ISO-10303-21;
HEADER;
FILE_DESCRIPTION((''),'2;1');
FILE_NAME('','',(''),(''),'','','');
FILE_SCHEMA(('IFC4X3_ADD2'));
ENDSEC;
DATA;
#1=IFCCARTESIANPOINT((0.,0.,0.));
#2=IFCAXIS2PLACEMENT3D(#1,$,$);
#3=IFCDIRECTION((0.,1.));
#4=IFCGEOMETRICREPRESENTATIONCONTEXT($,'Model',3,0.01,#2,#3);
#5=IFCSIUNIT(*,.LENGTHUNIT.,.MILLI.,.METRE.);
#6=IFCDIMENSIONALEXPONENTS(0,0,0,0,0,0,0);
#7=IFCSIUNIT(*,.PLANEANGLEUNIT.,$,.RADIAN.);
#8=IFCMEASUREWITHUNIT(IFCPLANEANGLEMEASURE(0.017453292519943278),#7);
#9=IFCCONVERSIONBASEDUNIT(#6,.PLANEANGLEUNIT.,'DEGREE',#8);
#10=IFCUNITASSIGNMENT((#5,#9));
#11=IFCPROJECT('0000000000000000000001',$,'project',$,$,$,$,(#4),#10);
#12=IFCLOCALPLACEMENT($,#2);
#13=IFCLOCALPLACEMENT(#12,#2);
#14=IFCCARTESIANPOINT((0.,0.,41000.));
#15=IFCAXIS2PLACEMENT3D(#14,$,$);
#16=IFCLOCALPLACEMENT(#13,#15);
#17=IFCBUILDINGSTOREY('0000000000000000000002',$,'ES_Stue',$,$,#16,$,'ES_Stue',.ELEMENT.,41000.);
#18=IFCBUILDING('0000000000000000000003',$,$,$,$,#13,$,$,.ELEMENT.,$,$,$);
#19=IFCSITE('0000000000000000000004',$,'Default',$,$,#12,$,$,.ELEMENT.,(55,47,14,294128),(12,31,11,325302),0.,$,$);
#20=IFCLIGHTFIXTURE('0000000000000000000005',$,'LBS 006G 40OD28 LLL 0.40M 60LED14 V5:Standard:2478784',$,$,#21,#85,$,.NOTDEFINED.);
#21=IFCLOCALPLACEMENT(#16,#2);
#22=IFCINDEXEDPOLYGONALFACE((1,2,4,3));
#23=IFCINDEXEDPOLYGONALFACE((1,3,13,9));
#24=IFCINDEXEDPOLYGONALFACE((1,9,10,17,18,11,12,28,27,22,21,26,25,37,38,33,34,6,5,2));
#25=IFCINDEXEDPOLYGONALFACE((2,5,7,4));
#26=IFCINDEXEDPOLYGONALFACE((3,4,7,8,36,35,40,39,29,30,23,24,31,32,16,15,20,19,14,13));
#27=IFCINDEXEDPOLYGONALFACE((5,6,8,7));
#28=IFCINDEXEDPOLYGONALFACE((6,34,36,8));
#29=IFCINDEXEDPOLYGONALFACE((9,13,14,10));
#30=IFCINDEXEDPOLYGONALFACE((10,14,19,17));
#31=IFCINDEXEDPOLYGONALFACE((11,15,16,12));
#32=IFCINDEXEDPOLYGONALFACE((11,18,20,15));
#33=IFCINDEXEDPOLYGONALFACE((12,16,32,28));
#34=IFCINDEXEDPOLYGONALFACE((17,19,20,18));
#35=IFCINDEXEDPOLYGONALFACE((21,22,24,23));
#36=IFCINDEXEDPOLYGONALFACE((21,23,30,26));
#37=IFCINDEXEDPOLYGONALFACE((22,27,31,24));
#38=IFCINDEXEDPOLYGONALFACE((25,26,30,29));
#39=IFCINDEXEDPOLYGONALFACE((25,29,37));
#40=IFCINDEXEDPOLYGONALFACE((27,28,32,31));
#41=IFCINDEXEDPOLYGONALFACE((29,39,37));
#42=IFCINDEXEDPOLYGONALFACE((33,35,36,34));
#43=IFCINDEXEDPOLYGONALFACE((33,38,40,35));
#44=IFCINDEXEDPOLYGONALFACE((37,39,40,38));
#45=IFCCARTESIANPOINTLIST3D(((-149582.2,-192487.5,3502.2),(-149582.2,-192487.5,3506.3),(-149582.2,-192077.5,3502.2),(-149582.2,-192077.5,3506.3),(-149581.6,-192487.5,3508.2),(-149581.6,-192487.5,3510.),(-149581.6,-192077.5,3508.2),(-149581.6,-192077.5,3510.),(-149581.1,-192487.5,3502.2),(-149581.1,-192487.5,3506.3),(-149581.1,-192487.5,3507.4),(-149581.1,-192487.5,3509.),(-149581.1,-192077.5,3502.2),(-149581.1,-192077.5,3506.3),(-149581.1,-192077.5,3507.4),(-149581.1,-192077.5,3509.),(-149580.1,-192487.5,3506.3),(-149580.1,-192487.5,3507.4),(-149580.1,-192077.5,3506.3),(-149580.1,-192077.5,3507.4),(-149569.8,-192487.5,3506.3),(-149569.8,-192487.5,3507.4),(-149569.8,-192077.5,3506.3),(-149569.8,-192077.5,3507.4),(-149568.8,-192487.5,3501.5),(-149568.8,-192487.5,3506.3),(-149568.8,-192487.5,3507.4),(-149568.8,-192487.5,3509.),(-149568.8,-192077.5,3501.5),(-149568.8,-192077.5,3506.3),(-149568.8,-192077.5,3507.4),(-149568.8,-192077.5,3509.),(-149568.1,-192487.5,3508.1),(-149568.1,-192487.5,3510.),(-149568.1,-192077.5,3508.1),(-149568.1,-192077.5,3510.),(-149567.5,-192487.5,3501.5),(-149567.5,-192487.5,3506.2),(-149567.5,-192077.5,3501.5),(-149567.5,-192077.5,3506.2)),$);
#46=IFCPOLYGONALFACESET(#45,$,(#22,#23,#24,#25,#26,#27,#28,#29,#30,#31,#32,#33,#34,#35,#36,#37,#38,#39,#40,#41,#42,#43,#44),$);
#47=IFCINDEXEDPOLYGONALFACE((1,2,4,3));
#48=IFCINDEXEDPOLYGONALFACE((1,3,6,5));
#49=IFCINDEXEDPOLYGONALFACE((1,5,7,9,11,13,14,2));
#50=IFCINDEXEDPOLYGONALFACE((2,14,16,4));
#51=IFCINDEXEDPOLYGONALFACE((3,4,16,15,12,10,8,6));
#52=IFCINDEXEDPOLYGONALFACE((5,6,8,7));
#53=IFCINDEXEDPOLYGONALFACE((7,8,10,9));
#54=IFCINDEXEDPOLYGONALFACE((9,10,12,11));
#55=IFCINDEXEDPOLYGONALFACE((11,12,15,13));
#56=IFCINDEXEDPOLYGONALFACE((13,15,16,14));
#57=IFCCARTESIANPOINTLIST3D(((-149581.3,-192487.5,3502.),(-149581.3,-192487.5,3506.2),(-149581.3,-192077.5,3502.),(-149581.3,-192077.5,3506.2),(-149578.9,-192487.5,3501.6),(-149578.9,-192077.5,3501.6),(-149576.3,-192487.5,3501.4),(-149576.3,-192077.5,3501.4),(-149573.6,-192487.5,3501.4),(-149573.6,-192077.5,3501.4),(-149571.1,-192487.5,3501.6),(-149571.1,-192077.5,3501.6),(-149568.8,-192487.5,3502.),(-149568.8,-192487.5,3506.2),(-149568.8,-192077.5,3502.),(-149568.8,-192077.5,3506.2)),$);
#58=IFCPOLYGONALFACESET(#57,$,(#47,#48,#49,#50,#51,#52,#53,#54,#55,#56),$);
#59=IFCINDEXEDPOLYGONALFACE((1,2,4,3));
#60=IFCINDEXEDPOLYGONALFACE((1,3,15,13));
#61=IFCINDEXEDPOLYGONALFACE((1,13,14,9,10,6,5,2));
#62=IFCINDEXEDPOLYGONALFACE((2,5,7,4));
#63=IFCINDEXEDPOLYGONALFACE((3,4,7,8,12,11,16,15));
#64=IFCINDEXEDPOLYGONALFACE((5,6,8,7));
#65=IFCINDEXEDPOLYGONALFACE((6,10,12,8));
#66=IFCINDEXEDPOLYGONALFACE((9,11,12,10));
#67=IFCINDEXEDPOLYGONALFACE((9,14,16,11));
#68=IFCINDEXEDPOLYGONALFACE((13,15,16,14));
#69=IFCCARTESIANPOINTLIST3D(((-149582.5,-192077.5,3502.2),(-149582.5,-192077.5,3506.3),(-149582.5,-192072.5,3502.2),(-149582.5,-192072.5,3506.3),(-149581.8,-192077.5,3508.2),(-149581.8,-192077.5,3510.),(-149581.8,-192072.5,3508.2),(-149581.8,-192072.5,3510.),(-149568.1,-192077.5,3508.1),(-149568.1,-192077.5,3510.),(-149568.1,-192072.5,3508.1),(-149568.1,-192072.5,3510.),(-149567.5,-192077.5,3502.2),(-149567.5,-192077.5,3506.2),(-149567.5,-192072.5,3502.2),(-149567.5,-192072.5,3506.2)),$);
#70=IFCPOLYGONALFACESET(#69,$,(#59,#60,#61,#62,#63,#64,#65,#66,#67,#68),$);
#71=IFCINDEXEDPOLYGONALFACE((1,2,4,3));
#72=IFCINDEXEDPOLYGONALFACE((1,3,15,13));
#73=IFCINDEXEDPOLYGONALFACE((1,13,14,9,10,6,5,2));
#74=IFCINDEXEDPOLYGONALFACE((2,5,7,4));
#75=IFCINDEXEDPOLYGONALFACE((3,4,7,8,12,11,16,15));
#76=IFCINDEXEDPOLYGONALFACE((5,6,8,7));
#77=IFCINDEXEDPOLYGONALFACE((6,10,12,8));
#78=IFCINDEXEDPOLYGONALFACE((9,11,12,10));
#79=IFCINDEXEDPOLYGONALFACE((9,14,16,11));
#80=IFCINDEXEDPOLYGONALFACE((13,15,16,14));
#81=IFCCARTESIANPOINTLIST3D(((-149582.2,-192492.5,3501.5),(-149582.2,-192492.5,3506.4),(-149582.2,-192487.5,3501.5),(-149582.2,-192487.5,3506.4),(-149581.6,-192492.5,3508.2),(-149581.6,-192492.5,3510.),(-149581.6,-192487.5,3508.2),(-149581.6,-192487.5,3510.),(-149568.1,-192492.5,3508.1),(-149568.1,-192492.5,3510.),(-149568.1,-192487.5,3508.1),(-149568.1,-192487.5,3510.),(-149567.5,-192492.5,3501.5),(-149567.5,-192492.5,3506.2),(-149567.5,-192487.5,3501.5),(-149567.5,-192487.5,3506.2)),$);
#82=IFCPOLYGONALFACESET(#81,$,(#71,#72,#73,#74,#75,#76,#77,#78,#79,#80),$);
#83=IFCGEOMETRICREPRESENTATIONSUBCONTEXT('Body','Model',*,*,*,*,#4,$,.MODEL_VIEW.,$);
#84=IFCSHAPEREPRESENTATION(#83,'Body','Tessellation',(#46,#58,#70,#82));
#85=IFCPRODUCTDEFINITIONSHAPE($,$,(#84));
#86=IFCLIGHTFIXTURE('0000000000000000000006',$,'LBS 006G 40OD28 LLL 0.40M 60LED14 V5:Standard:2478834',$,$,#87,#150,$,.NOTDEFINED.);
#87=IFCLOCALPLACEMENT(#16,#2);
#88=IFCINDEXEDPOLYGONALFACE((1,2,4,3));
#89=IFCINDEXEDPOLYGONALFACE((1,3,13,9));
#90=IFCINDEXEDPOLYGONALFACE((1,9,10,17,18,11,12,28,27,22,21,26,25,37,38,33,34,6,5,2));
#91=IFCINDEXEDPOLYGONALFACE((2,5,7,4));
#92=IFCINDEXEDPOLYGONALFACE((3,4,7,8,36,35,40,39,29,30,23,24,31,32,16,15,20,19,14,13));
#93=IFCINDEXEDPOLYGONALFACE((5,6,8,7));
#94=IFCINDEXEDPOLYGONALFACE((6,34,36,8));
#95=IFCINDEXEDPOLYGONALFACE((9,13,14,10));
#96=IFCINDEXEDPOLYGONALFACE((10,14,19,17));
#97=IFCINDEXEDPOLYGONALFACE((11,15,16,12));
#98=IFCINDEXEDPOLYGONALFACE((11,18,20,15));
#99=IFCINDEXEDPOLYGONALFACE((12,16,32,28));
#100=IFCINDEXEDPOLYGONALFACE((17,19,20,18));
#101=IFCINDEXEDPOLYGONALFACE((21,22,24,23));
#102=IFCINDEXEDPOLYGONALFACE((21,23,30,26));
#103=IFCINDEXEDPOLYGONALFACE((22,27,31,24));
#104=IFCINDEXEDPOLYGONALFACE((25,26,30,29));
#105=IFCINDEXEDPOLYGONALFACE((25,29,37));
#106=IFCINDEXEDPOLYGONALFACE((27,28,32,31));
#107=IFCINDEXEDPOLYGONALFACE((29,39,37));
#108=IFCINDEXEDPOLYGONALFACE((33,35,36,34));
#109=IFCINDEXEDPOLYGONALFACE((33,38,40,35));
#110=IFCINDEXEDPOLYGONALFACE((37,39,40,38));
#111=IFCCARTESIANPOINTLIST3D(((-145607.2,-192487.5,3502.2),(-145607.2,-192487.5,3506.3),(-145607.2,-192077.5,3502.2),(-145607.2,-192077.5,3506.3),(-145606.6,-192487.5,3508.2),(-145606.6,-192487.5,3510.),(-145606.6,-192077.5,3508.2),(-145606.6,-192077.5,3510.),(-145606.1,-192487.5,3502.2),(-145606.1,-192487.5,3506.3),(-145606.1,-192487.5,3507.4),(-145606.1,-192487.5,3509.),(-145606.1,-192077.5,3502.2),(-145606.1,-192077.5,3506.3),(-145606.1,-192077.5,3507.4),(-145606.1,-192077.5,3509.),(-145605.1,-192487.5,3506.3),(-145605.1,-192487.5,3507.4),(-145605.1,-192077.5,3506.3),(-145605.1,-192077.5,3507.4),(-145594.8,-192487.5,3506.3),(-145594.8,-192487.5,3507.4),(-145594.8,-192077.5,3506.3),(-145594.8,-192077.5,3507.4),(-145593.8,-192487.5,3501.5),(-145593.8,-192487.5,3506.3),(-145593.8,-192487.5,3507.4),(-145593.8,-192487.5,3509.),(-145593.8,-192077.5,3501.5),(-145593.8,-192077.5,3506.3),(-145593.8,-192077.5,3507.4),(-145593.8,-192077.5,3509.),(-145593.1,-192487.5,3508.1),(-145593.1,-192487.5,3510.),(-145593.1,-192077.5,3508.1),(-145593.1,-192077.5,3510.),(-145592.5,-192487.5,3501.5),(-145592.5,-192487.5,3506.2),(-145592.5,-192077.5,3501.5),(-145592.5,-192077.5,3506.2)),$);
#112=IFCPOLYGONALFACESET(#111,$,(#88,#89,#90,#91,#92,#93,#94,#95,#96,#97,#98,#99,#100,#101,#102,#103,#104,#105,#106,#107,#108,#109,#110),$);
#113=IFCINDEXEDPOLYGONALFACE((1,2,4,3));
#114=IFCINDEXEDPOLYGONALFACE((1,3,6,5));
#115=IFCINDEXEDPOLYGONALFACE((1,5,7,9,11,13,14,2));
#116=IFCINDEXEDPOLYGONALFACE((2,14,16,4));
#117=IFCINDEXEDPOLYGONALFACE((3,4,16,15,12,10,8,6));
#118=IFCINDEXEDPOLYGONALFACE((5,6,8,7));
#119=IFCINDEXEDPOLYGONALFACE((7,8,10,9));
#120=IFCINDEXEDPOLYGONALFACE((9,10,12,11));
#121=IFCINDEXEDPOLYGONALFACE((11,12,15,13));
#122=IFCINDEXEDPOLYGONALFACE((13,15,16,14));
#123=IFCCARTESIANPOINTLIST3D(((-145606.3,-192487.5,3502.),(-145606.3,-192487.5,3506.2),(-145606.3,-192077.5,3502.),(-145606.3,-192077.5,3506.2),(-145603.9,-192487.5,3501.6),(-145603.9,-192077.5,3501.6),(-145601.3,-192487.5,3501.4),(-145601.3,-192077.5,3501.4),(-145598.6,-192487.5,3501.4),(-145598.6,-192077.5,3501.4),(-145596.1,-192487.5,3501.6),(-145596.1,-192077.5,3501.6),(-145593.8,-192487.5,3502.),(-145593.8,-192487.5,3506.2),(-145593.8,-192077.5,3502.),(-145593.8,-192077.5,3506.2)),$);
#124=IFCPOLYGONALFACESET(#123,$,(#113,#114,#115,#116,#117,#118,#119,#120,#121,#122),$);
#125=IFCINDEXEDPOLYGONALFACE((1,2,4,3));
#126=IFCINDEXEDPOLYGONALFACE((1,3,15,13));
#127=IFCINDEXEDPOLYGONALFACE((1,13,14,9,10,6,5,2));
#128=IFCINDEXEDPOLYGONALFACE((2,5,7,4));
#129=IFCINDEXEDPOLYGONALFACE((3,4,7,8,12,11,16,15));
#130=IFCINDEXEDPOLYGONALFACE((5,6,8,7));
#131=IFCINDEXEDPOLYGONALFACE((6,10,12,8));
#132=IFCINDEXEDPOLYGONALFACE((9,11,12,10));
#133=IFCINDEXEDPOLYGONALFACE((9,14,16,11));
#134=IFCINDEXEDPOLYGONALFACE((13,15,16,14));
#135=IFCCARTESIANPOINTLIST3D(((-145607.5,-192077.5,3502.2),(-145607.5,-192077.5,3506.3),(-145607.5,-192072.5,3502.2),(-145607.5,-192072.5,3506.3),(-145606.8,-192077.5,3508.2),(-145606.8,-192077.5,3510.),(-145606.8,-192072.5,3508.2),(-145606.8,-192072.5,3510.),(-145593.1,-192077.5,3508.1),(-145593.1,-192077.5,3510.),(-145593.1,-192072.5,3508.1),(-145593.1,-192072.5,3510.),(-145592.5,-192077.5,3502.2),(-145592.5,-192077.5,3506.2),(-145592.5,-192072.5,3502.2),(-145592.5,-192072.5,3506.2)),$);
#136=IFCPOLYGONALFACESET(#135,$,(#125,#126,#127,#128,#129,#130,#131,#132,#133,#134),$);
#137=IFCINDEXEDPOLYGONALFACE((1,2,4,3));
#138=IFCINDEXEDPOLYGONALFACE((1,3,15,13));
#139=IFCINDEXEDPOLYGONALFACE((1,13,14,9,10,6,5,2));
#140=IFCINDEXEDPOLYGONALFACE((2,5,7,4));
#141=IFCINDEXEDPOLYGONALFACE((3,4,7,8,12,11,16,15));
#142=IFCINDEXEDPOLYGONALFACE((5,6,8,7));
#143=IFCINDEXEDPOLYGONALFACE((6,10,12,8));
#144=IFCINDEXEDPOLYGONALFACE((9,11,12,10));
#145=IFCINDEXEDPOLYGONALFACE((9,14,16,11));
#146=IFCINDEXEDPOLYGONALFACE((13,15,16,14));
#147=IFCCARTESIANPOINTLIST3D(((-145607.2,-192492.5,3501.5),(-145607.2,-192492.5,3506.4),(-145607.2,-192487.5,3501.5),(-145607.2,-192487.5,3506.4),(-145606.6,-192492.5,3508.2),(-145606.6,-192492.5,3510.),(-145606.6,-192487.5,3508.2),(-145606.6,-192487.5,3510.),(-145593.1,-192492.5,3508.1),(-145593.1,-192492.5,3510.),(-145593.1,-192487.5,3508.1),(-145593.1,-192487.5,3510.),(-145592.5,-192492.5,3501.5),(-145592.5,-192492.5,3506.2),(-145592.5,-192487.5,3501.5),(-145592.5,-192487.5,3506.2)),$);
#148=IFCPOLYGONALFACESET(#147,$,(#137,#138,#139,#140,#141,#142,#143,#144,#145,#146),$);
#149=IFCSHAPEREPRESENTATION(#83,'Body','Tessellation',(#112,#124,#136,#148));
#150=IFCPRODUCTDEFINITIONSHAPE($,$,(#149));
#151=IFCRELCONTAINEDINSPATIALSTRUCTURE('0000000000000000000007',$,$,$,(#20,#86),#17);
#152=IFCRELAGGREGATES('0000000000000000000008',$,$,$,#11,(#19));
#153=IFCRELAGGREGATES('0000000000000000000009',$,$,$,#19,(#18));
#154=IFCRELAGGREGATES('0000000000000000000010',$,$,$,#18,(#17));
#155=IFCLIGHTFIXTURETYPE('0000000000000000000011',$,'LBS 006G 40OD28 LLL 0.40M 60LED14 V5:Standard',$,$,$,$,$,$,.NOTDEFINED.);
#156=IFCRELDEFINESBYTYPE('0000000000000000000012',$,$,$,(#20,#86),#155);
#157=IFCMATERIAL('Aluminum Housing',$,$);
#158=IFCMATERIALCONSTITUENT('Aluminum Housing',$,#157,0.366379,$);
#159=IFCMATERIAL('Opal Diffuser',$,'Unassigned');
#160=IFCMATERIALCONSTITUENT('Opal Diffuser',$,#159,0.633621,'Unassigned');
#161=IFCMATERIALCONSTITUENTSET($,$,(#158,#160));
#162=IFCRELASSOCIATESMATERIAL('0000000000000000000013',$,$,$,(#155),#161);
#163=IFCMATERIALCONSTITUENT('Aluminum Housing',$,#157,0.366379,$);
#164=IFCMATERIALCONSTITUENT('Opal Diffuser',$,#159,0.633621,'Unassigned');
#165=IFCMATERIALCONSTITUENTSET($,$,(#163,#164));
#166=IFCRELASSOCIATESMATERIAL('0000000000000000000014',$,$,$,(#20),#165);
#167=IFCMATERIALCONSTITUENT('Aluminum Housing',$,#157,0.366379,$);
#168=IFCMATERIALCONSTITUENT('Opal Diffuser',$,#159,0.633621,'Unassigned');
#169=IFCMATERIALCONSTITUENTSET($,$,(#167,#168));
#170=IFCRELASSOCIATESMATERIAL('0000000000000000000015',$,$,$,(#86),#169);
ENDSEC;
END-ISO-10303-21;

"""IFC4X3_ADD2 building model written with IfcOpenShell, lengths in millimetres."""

from ifc_helpers import new_model, entity, si_unit, converted_unit, direction, frame, origin, place, context, subcontext, project, spatial, polyline, outline, extrude, source, transform, mapped, material, constituent, constituent_set, type_object, type_shapes, element, save


model = new_model("IFC4X3_ADD2")

# Units and contexts
model_context = context("Model", 3, precision=0.01, world=origin(), true_north=direction((0.0, 1.0)))
body_context = subcontext(model_context, "Body", "Model", "MODEL_VIEW")
ifc_project = project(units=[si_unit("LENGTHUNIT", "METRE", prefix="MILLI"), converted_unit("PLANEANGLEUNIT", "DEGREE", entity("IfcPlaneAngleMeasure", 0.017453292519943278), si_unit("PLANEANGLEUNIT", "RADIAN"), dimensions=[0, 0, 0, 0, 0, 0, 0])], contexts=[model_context])

# Site, building, storey
site_placement = place(None, origin())
site = spatial("IfcSite", under=ifc_project, at=site_placement, Name="Default", CompositionType="ELEMENT", RefLatitude=(55, 47, 14, 294128), RefLongitude=(12, 31, 11, 325302), RefElevation=0.0)
building_placement = place(site_placement, origin())
building = spatial("IfcBuilding", under=site, at=building_placement, CompositionType="ELEMENT")
storey_placement = place(building_placement, frame((0.0, 0.0, 41000.0)))
storey = spatial("IfcBuildingStorey", under=building, at=storey_placement, Name="ES_Stue", LongName="ES_Stue", CompositionType="ELEMENT", Elevation=41000.0)

# Light fixtures
ifc_material_1 = material(Name="Aluminum Housing")
ifc_constituent_1 = constituent(ifc_material_1, Name="Aluminum Housing", fraction=0.366379)
ifc_material_2 = material(Name="Opal Diffuser", Category="Unassigned")
ifc_constituent_2 = constituent(ifc_material_2, Name="Opal Diffuser", Category="Unassigned", fraction=0.633621)
ifc_constituent_set_1 = constituent_set(constituents=[ifc_constituent_1, ifc_constituent_2])
ifc_constituent_3 = constituent(ifc_material_1, Name="Aluminum Housing", fraction=0.366379)
ifc_constituent_4 = constituent(ifc_material_2, Name="Opal Diffuser", Category="Unassigned", fraction=0.633621)
ifc_constituent_set_2 = constituent_set(constituents=[ifc_constituent_3, ifc_constituent_4])
light_fixture_type = type_object("IfcLightFixtureType", Name="LBS 006G 40OD28 LLL 0.40M 60LED14 V5:Standard", PredefinedType="NOTDEFINED", material=ifc_constituent_set_2)
shared_shape_1 = source(origin(), body_context, "Body", "SweptSolid", [
    extrude(outline(polyline([(-5.0, -6.1), (-5.0, -7.4), (-0.3, -7.4), (1.7, -6.8), (3.5, -6.8), (3.5, 6.7), (1.8, 6.7), (-0.1, 7.3), (-4.2, 7.3), (-4.2, 6.2), (-0.1, 6.2), (-0.1, 5.2), (0.9, 5.2), (0.9, 6.2), (2.5, 6.2), (2.5, -6.1), (0.9, -6.1), (0.9, -5.1), (-0.1, -5.1), (-0.1, -6.1), (-5.0, -6.1)])), frame((-205.0, 0.1, 3.5), z_axis=(-1.0, 0.0, 0.0), x_axis=(0.0, 0.0, -1.0)), (0.0, 0.0, -1.0), 410.0),
    extrude(outline(polyline([(-0.8, -6.2), (3.4, -6.2), (3.4, 6.2), (-0.8, 6.2), (-1.2, 3.9), (-1.4, 1.4), (-1.4, -1.3), (-1.2, -3.9), (-0.8, -6.2)])), frame((-205.0, 0.0, 7.2), z_axis=(1.0, 0.0, 0.0), x_axis=(0.0, 0.0, -1.0)), (0.0, 0.0, 1.0), 410.0),
    extrude(outline(polyline([(-4.4, -7.5), (-0.3, -7.5), (1.5, -6.8), (3.3, -6.8), (3.3, 6.9), (1.5, 6.9), (-0.5, 7.4), (-4.4, 7.4), (-4.4, -7.5)])), frame((205.0, 0.0, 3.3), z_axis=(1.0, 0.0, 0.0), x_axis=(0.0, 0.0, -1.0)), (0.0, 0.0, 1.0), 5.0),
    extrude(outline(polyline([(-5.0, -7.4), (-0.1, -7.4), (1.7, -6.7), (3.5, -6.7), (3.5, 6.8), (1.6, 6.8), (-0.3, 7.3), (-5.0, 7.3), (-5.0, -7.4)])), frame((-210.0, 0.2, 3.5), z_axis=(1.0, 0.0, 0.0), x_axis=(0.0, 0.0, -1.0)), (0.0, 0.0, 1.0), 5.0),
])
type_shapes(light_fixture_type, [shared_shape_1])
light_fixture_1_placement = place(storey_placement, frame((-149575.0, -192282.5, 3510.0), z_axis=(0.0, 0.0, -1.0), x_axis=(0.0, 1.0, 0.0)))
element("IfcLightFixture", 1, at=light_fixture_1_placement, inside=storey, type_object=light_fixture_type, material=ifc_constituent_set_1, Name="LBS 006G 40OD28 LLL 0.40M 60LED14 V5:Standard:2478784", PredefinedType="NOTDEFINED", context=body_context, shape_type="MappedRepresentation", body=[
    mapped(shared_shape_1, transform((0.0, 0.0, 0.0), scale=1.0)),
])
ifc_constituent_5 = constituent(ifc_material_1, Name="Aluminum Housing", fraction=0.366379)
ifc_constituent_6 = constituent(ifc_material_2, Name="Opal Diffuser", Category="Unassigned", fraction=0.633621)
ifc_constituent_set_3 = constituent_set(constituents=[ifc_constituent_5, ifc_constituent_6])
light_fixture_2_placement = place(storey_placement, frame((-145600.0, -192282.5, 3510.0), z_axis=(0.0, 0.0, -1.0), x_axis=(0.0, 1.0, 0.0)))
element("IfcLightFixture", 2, at=light_fixture_2_placement, inside=storey, type_object=light_fixture_type, material=ifc_constituent_set_3, Name="LBS 006G 40OD28 LLL 0.40M 60LED14 V5:Standard:2478834", PredefinedType="NOTDEFINED", context=body_context, shape_type="MappedRepresentation", body=[
    mapped(shared_shape_1, transform((0.0, 0.0, 0.0), scale=1.0)),
])

save(model, "model.ifc")
